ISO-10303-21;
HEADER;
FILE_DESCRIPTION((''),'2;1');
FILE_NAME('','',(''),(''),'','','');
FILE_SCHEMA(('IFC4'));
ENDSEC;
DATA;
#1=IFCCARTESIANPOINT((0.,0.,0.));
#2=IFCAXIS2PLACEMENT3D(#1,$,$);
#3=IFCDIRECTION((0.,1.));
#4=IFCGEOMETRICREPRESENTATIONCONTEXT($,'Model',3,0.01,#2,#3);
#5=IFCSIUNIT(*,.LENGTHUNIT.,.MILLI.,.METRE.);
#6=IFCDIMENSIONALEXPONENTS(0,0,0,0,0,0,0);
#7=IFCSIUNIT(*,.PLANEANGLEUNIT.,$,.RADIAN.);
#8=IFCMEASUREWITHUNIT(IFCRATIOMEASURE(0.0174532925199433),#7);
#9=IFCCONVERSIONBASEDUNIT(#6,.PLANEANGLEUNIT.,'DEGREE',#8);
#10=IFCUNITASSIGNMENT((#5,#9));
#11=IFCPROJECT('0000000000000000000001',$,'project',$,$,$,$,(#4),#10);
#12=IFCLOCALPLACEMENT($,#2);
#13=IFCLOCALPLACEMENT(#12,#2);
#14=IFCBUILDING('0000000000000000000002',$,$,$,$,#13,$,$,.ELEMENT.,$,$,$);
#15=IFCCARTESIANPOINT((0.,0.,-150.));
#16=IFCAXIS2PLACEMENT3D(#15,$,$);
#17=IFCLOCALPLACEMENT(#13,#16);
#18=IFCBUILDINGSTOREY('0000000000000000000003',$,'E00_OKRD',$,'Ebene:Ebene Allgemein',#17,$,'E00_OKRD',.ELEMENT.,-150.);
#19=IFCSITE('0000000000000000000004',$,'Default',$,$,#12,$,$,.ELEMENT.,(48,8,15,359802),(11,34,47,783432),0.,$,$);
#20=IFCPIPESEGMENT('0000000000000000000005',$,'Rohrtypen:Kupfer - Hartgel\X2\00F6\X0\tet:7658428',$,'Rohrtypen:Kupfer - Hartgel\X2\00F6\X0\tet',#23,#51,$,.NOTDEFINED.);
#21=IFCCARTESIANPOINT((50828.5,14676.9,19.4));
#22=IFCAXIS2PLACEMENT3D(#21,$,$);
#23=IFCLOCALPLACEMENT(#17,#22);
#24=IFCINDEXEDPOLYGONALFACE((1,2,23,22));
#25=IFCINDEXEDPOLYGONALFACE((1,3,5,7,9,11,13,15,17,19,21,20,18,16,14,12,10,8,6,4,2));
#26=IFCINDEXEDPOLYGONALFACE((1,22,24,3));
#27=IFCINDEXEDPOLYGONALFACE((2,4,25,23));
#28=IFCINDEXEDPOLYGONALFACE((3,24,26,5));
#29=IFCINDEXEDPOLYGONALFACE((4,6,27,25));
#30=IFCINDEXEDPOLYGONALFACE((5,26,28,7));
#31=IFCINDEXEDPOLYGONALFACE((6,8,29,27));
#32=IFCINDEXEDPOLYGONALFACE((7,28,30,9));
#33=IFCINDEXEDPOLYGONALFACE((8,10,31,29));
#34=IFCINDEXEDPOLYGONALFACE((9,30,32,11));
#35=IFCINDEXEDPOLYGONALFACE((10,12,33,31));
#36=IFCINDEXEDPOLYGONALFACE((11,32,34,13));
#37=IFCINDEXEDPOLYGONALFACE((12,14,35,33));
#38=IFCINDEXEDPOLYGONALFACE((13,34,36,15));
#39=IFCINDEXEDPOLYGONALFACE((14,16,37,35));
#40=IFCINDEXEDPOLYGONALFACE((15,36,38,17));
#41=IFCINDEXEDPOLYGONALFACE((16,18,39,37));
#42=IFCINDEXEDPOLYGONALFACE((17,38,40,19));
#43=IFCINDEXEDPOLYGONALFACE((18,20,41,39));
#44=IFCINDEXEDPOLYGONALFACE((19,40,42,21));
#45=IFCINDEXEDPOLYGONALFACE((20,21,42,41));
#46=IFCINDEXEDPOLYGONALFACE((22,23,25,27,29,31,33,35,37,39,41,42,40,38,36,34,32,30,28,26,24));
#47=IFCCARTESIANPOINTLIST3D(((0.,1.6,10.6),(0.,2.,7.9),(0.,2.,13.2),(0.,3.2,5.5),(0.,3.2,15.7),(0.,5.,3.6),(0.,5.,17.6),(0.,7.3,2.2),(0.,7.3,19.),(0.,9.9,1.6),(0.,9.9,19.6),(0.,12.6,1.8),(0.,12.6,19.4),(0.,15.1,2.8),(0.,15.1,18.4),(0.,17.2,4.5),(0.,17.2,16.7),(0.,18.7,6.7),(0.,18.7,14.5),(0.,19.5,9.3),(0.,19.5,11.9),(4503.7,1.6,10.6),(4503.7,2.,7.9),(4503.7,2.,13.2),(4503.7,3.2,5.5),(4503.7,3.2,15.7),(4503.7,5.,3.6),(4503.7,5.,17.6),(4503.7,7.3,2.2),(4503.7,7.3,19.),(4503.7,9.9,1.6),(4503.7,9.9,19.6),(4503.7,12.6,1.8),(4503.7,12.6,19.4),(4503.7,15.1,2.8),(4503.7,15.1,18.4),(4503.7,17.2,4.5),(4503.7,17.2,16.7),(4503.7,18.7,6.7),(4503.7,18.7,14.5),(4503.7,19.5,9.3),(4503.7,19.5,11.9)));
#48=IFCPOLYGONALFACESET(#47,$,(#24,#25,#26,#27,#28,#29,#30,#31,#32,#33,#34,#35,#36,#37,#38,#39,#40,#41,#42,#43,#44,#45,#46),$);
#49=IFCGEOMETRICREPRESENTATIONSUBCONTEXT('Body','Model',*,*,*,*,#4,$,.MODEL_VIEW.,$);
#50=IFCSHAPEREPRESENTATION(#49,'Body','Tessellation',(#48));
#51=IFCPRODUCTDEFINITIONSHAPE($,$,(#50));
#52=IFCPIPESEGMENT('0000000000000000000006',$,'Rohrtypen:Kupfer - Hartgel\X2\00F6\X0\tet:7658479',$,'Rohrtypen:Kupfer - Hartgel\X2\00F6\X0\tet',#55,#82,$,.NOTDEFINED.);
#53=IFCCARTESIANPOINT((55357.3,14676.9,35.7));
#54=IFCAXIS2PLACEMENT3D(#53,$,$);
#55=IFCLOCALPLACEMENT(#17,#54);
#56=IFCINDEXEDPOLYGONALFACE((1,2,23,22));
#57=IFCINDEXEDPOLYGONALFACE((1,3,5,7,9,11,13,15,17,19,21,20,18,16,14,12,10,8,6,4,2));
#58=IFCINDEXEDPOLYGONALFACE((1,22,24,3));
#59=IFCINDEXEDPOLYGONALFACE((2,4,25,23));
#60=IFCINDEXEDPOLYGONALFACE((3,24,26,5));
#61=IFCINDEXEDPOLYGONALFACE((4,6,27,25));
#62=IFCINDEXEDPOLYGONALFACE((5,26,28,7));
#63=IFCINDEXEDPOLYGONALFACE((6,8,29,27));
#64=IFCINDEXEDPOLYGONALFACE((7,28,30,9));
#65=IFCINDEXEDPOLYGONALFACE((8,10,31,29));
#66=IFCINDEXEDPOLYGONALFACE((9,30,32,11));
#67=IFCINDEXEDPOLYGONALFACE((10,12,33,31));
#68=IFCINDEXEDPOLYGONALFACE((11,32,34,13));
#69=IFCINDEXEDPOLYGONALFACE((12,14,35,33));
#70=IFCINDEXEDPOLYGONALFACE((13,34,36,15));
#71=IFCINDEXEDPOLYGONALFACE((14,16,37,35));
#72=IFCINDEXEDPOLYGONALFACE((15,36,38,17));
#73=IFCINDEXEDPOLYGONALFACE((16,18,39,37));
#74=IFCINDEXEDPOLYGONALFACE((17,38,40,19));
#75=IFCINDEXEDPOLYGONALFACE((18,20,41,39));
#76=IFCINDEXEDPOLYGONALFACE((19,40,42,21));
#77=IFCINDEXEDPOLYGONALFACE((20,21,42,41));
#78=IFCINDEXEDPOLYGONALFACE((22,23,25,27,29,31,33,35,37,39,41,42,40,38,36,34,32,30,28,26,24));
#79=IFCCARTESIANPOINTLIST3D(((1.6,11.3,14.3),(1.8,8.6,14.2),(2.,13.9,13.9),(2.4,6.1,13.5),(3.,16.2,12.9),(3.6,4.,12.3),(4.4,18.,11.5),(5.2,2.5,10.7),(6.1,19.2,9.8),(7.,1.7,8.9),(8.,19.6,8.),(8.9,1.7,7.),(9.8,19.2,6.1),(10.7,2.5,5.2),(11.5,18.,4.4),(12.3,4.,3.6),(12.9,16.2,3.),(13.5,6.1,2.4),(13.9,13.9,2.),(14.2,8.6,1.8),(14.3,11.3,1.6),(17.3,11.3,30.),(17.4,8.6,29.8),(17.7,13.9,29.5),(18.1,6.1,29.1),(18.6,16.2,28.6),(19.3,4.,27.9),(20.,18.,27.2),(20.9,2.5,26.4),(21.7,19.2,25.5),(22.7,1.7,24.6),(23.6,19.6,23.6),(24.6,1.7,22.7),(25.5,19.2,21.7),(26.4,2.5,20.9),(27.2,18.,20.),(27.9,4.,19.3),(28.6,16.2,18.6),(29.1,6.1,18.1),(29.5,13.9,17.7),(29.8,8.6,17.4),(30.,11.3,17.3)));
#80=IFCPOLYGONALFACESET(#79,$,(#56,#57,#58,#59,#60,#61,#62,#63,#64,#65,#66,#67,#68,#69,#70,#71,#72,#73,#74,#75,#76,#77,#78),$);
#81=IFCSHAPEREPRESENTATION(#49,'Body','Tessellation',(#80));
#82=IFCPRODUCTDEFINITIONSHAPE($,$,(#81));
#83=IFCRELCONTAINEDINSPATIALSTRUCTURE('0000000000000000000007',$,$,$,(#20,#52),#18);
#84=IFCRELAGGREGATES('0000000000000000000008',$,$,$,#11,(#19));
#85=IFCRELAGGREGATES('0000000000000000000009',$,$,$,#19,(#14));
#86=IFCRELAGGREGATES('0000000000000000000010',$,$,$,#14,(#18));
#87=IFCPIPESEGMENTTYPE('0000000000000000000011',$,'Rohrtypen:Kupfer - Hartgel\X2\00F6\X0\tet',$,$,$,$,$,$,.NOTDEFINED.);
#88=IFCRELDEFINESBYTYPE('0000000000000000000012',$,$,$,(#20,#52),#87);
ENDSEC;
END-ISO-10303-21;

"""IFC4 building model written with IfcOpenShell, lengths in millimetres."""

from ifc_helpers import new_model, entity, si_unit, converted_unit, direction, frame, frame_2d, origin, origin_2d_with_axis, place, context, subcontext, project, spatial, circle, extrude, type_object, element, save


model = new_model("IFC4")

# Units and contexts
model_context = context("Model", 3, precision=0.01, world=origin(), true_north=direction((0.0, 1.0)))
body_context = subcontext(model_context, "Body", "Model", "MODEL_VIEW")
ifc_project = project(units=[si_unit("LENGTHUNIT", "METRE", prefix="MILLI"), converted_unit("PLANEANGLEUNIT", "DEGREE", entity("IfcRatioMeasure", 0.0174532925199433), si_unit("PLANEANGLEUNIT", "RADIAN"), dimensions=[0, 0, 0, 0, 0, 0, 0])], contexts=[model_context])

# Site, building, storey
site_placement = place(None, origin())
site = spatial("IfcSite", under=ifc_project, at=site_placement, Name="Default", CompositionType="ELEMENT", RefLatitude=(48, 8, 15, 359802), RefLongitude=(11, 34, 47, 783432), RefElevation=0.0)
building_placement = place(site_placement, origin())
building = spatial("IfcBuilding", under=site, at=building_placement, CompositionType="ELEMENT")
storey_placement = place(building_placement, frame((0.0, 0.0, -150.0)))
storey = spatial("IfcBuildingStorey", under=building, at=storey_placement, Name="E00_OKRD", ObjectType="Ebene:Ebene Allgemein", LongName="E00_OKRD", CompositionType="ELEMENT", Elevation=-150.0)

# Pipe segments
pipe_segment_type = type_object("IfcPipeSegmentType", Name="Rohrtypen:Kupfer - Hartgelötet", PredefinedType="NOTDEFINED")
pipe_segment_1_placement = place(storey_placement, frame((50828.5, 14676.9, 19.4)))
element("IfcPipeSegment", 1, at=pipe_segment_1_placement, inside=storey, type_object=pipe_segment_type, Name="Rohrtypen:Kupfer - Hartgelötet:7658428", ObjectType="Rohrtypen:Kupfer - Hartgelötet", PredefinedType="NOTDEFINED", context=body_context, shape_type="SweptSolid", body=[
    extrude(circle(Radius=9.0, at=frame_2d((0.0, 0.0), x_axis=(1.0, 0.0))), frame((0.0, 10.6, 10.6), z_axis=(1.0, 0.0, 0.0), x_axis=(0.0, -1.0, 0.0)), (0.0, 0.0, 1.0), 4503.7),
])
pipe_segment_2_placement = place(storey_placement, frame((55357.3, 14676.9, 35.7)))
element("IfcPipeSegment", 2, at=pipe_segment_2_placement, inside=storey, type_object=pipe_segment_type, Name="Rohrtypen:Kupfer - Hartgelötet:7658479", ObjectType="Rohrtypen:Kupfer - Hartgelötet", PredefinedType="NOTDEFINED", context=body_context, shape_type="SweptSolid", body=[
    extrude(circle(Radius=9.0, at=origin_2d_with_axis()), frame((8.0, 10.6, 8.0), z_axis=(0.707107, 0.0, 0.707107), x_axis=(0.0, 1.0, 0.0)), (0.0, 0.0, 1.0), 22.1),
])

save(model, "model.ifc")
